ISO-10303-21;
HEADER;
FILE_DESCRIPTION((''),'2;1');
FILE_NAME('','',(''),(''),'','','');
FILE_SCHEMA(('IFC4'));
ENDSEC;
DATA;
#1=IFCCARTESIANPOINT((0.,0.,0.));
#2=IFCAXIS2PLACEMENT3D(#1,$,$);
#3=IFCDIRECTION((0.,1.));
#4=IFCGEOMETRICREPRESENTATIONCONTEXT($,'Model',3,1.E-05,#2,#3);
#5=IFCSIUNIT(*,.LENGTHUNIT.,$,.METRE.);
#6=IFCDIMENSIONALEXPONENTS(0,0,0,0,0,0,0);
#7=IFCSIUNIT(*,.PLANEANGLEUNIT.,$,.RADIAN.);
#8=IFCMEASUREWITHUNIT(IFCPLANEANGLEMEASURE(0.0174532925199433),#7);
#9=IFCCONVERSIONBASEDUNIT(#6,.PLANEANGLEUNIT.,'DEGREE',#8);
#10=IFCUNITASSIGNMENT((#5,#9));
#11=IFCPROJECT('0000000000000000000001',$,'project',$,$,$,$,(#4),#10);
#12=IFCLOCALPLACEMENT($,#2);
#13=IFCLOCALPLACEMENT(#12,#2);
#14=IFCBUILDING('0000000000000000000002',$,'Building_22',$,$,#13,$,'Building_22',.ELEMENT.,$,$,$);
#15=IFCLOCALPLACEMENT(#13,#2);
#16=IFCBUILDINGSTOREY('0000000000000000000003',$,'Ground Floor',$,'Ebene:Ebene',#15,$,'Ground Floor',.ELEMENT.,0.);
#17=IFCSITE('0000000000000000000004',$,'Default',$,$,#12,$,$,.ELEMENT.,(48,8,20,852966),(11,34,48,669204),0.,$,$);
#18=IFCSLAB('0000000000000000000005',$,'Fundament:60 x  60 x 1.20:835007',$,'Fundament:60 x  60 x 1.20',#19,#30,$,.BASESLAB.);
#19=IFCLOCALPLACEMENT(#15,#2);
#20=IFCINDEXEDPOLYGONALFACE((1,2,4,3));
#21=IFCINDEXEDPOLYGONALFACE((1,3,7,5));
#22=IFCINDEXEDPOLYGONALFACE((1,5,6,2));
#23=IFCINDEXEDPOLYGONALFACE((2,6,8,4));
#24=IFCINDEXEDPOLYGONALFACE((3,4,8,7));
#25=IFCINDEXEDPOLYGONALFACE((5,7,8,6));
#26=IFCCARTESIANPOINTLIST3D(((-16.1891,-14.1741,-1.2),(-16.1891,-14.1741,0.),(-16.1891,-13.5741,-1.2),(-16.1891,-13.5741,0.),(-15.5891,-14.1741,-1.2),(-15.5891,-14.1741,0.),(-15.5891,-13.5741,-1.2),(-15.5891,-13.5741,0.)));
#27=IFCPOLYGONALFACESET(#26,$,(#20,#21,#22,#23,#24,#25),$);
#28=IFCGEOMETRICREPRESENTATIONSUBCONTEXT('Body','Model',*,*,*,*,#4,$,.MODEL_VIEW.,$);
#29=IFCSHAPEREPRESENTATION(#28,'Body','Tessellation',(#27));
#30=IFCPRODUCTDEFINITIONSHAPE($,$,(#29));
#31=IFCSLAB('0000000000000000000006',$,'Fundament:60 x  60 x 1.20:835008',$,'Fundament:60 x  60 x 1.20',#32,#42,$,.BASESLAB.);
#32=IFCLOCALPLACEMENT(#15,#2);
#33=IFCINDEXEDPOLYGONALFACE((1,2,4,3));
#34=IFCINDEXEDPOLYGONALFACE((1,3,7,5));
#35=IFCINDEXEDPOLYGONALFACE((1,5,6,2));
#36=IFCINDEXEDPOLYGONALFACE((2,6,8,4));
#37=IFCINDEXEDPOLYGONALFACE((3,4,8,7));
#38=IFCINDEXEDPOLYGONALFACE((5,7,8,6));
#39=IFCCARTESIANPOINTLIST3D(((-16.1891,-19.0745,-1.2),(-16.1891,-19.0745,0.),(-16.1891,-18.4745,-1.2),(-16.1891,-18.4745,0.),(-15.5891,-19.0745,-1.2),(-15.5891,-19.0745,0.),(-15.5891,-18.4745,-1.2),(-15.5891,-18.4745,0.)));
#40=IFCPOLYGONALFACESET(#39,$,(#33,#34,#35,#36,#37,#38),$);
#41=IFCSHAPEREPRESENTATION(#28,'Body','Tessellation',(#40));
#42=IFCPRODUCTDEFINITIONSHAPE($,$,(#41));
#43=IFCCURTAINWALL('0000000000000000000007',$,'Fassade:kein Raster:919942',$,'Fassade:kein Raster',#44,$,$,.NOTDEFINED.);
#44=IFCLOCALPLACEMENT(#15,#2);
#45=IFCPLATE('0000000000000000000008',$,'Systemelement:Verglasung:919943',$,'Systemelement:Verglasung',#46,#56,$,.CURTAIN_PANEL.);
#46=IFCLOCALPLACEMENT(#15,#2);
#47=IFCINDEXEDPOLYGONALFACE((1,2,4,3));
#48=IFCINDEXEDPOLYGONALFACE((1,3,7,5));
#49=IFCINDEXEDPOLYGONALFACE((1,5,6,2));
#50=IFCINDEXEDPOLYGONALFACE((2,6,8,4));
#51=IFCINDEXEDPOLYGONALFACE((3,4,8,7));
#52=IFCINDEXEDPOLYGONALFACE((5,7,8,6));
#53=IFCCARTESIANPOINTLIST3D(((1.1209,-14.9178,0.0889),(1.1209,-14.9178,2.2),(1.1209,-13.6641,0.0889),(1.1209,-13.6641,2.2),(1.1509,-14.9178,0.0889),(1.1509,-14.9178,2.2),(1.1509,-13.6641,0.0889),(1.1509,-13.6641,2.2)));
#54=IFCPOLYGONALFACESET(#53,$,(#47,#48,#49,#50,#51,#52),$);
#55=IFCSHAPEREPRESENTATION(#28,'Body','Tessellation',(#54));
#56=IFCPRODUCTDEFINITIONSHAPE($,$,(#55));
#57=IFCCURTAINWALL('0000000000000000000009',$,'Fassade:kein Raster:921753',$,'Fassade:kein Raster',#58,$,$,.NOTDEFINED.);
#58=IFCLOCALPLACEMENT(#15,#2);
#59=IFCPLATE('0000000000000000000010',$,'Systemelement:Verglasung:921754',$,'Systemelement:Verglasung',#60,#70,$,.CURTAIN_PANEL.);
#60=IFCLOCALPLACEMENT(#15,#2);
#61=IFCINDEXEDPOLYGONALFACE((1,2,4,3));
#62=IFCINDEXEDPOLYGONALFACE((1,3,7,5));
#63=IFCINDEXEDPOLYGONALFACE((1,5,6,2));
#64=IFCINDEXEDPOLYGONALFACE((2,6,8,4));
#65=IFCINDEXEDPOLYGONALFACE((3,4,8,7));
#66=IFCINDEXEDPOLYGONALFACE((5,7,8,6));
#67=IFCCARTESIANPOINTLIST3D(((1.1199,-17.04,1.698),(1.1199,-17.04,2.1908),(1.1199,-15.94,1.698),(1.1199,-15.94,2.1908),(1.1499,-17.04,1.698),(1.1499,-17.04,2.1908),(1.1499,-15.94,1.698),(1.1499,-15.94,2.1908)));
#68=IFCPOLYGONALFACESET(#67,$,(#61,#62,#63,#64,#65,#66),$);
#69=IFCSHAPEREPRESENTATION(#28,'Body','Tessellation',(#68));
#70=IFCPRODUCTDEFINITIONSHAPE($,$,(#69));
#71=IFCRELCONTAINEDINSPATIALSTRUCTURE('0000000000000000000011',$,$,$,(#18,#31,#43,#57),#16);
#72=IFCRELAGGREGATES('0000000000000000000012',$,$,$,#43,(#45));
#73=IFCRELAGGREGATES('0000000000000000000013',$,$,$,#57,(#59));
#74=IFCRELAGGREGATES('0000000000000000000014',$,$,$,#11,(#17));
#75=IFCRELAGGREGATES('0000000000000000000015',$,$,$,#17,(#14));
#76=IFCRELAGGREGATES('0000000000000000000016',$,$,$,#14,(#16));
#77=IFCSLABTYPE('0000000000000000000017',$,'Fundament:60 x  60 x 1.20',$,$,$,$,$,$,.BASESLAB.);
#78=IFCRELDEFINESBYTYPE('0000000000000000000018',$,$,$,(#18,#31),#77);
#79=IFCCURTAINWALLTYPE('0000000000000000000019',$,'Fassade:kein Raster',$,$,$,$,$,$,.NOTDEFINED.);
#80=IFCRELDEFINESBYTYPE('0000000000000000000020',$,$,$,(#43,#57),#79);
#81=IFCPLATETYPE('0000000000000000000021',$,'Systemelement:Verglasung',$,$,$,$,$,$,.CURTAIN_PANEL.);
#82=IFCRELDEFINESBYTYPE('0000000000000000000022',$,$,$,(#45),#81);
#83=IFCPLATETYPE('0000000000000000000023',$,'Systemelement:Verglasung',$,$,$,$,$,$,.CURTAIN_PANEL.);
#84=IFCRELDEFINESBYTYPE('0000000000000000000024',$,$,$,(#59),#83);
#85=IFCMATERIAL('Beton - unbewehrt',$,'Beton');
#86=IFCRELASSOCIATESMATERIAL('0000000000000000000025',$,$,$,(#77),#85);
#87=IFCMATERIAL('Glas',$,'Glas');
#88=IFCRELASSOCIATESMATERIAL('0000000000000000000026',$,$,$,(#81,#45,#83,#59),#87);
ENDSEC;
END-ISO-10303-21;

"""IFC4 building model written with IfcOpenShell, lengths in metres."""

from ifc_helpers import new_model, entity, si_unit, converted_unit, direction, frame, origin, place, context, subcontext, project, spatial, indexed_curve, outline, extrude, source, transform, mapped, material, type_object, type_shapes, element, aggregate, save


model = new_model("IFC4")

# Units and contexts
model_context = context("Model", 3, precision=1e-05, world=origin(), true_north=direction((0.0, 1.0)))
body_context = subcontext(model_context, "Body", "Model", "MODEL_VIEW")
ifc_project = project(units=[si_unit("LENGTHUNIT", "METRE"), converted_unit("PLANEANGLEUNIT", "DEGREE", entity("IfcPlaneAngleMeasure", 0.0174532925199433), si_unit("PLANEANGLEUNIT", "RADIAN"), dimensions=[0, 0, 0, 0, 0, 0, 0])], contexts=[model_context])

# Site, building, storey
site_placement = place(None, origin())
site = spatial("IfcSite", under=ifc_project, at=site_placement, Name="Default", CompositionType="ELEMENT", RefLatitude=(48, 8, 20, 852966), RefLongitude=(11, 34, 48, 669204), RefElevation=0.0)
building_placement = place(site_placement, origin())
building = spatial("IfcBuilding", under=site, at=building_placement, Name="Building_22", LongName="Building_22", CompositionType="ELEMENT")
storey_placement = place(building_placement, origin())
storey = spatial("IfcBuildingStorey", under=building, at=storey_placement, Name="Ground Floor", ObjectType="Ebene:Ebene", LongName="Ground Floor", CompositionType="ELEMENT", Elevation=0.0)

# Shared definitions
curtain_wall_type = type_object("IfcCurtainWallType", Name="Fassade:kein Raster", PredefinedType="NOTDEFINED")
ifc_material_1 = material(Name="Glas", Category="Glas")

# Slabs
ifc_material_2 = material(Name="Beton - unbewehrt", Category="Beton")
slab_type_1 = type_object("IfcSlabType", Name="Fundament:60 x  60 x 1.20", PredefinedType="BASESLAB", material=ifc_material_2)
slab_1_placement = place(storey_placement, origin())
element("IfcSlab", 1, at=slab_1_placement, inside=storey, type_object=slab_type_1, Name="Fundament:60 x  60 x 1.20:835007", ObjectType="Fundament:60 x  60 x 1.20", PredefinedType="BASESLAB", context=body_context, shape_type="SweptSolid", body=[
    extrude(outline(indexed_curve([(-0.3, -0.3), (0.3, -0.3), (0.3, 0.3), (-0.3, 0.3), (-0.3, -0.3)], self_intersect=False)), frame((-15.8891, -13.8741, -1.2), z_axis=(0.0, 0.0, 1.0), x_axis=(-1.0, 0.0, 0.0)), (0.0, 0.0, 1.0), 1.2),
])
slab_2_placement = place(storey_placement, origin())
element("IfcSlab", 2, at=slab_2_placement, inside=storey, type_object=slab_type_1, Name="Fundament:60 x  60 x 1.20:835008", ObjectType="Fundament:60 x  60 x 1.20", PredefinedType="BASESLAB", context=body_context, shape_type="SweptSolid", body=[
    extrude(outline(indexed_curve([(-0.3, -0.3), (0.3, -0.3), (0.3, 0.3), (-0.3, 0.3), (-0.3, -0.3)], self_intersect=False)), frame((-15.8891, -18.7745, -1.2), z_axis=(0.0, 0.0, 1.0), x_axis=(-1.0, 0.0, 0.0)), (0.0, 0.0, 1.0), 1.2),
])

# Curtain walls, plates
curtain_wall_1_placement = place(storey_placement, origin())
curtain_wall_1 = element("IfcCurtainWall", 3, at=curtain_wall_1_placement, inside=storey, type_object=curtain_wall_type, Name="Fassade:kein Raster:919942", ObjectType="Fassade:kein Raster", PredefinedType="NOTDEFINED")
plate_type_1 = type_object("IfcPlateType", Name="Systemelement:Verglasung", PredefinedType="CURTAIN_PANEL", material=ifc_material_1)
shared_shape_1 = source(origin(), body_context, "Body", "SweptSolid", [
    extrude(outline(indexed_curve([(-0.015, -0.6268), (0.015, -0.6268), (0.015, 0.6268), (-0.015, 0.6268), (-0.015, -0.6268)], self_intersect=False)), frame((0.0, 0.0, 0.0), z_axis=(0.0, 0.0, 1.0), x_axis=(0.0, 1.0, 0.0)), (0.0, 0.0, 1.0), 2.1111),
])
type_shapes(plate_type_1, [shared_shape_1])
plate_1_placement = place(curtain_wall_1_placement, frame((1.1359, -14.291, 0.0889), z_axis=(0.0, 0.0, 1.0), x_axis=(0.0, -1.0, 0.0)))
plate_1 = element("IfcPlate", 4, at=plate_1_placement, type_object=plate_type_1, material=ifc_material_1, Name="Systemelement:Verglasung:919943", ObjectType="Systemelement:Verglasung", PredefinedType="CURTAIN_PANEL", context=body_context, shape_type="MappedRepresentation", body=[
    mapped(shared_shape_1, transform((0.0, 0.0, 0.0), scale=1.0)),
])
aggregate(curtain_wall_1, [plate_1])
curtain_wall_2_placement = place(storey_placement, origin())
curtain_wall_2 = element("IfcCurtainWall", 5, at=curtain_wall_2_placement, inside=storey, type_object=curtain_wall_type, Name="Fassade:kein Raster:921753", ObjectType="Fassade:kein Raster", PredefinedType="NOTDEFINED")
plate_type_2 = type_object("IfcPlateType", Name="Systemelement:Verglasung", PredefinedType="CURTAIN_PANEL", material=ifc_material_1)
shared_shape_2 = source(origin(), body_context, "Body", "SweptSolid", [
    extrude(outline(indexed_curve([(-0.015, -0.55), (0.015, -0.55), (0.015, 0.55), (-0.015, 0.55), (-0.015, -0.55)], self_intersect=False)), frame((0.0, 0.0, 0.0), z_axis=(0.0, 0.0, 1.0), x_axis=(0.0, 1.0, 0.0)), (0.0, 0.0, 1.0), 0.4929),
])
type_shapes(plate_type_2, [shared_shape_2])
plate_2_placement = place(curtain_wall_2_placement, frame((1.1349, -16.49, 1.698), z_axis=(0.0, 0.0, 1.0), x_axis=(0.0, -1.0, 0.0)))
plate_2 = element("IfcPlate", 6, at=plate_2_placement, type_object=plate_type_2, material=ifc_material_1, Name="Systemelement:Verglasung:921754", ObjectType="Systemelement:Verglasung", PredefinedType="CURTAIN_PANEL", context=body_context, shape_type="MappedRepresentation", body=[
    mapped(shared_shape_2, transform((0.0, 0.0, 0.0), scale=1.0)),
])
aggregate(curtain_wall_2, [plate_2])

save(model, "model.ifc")
